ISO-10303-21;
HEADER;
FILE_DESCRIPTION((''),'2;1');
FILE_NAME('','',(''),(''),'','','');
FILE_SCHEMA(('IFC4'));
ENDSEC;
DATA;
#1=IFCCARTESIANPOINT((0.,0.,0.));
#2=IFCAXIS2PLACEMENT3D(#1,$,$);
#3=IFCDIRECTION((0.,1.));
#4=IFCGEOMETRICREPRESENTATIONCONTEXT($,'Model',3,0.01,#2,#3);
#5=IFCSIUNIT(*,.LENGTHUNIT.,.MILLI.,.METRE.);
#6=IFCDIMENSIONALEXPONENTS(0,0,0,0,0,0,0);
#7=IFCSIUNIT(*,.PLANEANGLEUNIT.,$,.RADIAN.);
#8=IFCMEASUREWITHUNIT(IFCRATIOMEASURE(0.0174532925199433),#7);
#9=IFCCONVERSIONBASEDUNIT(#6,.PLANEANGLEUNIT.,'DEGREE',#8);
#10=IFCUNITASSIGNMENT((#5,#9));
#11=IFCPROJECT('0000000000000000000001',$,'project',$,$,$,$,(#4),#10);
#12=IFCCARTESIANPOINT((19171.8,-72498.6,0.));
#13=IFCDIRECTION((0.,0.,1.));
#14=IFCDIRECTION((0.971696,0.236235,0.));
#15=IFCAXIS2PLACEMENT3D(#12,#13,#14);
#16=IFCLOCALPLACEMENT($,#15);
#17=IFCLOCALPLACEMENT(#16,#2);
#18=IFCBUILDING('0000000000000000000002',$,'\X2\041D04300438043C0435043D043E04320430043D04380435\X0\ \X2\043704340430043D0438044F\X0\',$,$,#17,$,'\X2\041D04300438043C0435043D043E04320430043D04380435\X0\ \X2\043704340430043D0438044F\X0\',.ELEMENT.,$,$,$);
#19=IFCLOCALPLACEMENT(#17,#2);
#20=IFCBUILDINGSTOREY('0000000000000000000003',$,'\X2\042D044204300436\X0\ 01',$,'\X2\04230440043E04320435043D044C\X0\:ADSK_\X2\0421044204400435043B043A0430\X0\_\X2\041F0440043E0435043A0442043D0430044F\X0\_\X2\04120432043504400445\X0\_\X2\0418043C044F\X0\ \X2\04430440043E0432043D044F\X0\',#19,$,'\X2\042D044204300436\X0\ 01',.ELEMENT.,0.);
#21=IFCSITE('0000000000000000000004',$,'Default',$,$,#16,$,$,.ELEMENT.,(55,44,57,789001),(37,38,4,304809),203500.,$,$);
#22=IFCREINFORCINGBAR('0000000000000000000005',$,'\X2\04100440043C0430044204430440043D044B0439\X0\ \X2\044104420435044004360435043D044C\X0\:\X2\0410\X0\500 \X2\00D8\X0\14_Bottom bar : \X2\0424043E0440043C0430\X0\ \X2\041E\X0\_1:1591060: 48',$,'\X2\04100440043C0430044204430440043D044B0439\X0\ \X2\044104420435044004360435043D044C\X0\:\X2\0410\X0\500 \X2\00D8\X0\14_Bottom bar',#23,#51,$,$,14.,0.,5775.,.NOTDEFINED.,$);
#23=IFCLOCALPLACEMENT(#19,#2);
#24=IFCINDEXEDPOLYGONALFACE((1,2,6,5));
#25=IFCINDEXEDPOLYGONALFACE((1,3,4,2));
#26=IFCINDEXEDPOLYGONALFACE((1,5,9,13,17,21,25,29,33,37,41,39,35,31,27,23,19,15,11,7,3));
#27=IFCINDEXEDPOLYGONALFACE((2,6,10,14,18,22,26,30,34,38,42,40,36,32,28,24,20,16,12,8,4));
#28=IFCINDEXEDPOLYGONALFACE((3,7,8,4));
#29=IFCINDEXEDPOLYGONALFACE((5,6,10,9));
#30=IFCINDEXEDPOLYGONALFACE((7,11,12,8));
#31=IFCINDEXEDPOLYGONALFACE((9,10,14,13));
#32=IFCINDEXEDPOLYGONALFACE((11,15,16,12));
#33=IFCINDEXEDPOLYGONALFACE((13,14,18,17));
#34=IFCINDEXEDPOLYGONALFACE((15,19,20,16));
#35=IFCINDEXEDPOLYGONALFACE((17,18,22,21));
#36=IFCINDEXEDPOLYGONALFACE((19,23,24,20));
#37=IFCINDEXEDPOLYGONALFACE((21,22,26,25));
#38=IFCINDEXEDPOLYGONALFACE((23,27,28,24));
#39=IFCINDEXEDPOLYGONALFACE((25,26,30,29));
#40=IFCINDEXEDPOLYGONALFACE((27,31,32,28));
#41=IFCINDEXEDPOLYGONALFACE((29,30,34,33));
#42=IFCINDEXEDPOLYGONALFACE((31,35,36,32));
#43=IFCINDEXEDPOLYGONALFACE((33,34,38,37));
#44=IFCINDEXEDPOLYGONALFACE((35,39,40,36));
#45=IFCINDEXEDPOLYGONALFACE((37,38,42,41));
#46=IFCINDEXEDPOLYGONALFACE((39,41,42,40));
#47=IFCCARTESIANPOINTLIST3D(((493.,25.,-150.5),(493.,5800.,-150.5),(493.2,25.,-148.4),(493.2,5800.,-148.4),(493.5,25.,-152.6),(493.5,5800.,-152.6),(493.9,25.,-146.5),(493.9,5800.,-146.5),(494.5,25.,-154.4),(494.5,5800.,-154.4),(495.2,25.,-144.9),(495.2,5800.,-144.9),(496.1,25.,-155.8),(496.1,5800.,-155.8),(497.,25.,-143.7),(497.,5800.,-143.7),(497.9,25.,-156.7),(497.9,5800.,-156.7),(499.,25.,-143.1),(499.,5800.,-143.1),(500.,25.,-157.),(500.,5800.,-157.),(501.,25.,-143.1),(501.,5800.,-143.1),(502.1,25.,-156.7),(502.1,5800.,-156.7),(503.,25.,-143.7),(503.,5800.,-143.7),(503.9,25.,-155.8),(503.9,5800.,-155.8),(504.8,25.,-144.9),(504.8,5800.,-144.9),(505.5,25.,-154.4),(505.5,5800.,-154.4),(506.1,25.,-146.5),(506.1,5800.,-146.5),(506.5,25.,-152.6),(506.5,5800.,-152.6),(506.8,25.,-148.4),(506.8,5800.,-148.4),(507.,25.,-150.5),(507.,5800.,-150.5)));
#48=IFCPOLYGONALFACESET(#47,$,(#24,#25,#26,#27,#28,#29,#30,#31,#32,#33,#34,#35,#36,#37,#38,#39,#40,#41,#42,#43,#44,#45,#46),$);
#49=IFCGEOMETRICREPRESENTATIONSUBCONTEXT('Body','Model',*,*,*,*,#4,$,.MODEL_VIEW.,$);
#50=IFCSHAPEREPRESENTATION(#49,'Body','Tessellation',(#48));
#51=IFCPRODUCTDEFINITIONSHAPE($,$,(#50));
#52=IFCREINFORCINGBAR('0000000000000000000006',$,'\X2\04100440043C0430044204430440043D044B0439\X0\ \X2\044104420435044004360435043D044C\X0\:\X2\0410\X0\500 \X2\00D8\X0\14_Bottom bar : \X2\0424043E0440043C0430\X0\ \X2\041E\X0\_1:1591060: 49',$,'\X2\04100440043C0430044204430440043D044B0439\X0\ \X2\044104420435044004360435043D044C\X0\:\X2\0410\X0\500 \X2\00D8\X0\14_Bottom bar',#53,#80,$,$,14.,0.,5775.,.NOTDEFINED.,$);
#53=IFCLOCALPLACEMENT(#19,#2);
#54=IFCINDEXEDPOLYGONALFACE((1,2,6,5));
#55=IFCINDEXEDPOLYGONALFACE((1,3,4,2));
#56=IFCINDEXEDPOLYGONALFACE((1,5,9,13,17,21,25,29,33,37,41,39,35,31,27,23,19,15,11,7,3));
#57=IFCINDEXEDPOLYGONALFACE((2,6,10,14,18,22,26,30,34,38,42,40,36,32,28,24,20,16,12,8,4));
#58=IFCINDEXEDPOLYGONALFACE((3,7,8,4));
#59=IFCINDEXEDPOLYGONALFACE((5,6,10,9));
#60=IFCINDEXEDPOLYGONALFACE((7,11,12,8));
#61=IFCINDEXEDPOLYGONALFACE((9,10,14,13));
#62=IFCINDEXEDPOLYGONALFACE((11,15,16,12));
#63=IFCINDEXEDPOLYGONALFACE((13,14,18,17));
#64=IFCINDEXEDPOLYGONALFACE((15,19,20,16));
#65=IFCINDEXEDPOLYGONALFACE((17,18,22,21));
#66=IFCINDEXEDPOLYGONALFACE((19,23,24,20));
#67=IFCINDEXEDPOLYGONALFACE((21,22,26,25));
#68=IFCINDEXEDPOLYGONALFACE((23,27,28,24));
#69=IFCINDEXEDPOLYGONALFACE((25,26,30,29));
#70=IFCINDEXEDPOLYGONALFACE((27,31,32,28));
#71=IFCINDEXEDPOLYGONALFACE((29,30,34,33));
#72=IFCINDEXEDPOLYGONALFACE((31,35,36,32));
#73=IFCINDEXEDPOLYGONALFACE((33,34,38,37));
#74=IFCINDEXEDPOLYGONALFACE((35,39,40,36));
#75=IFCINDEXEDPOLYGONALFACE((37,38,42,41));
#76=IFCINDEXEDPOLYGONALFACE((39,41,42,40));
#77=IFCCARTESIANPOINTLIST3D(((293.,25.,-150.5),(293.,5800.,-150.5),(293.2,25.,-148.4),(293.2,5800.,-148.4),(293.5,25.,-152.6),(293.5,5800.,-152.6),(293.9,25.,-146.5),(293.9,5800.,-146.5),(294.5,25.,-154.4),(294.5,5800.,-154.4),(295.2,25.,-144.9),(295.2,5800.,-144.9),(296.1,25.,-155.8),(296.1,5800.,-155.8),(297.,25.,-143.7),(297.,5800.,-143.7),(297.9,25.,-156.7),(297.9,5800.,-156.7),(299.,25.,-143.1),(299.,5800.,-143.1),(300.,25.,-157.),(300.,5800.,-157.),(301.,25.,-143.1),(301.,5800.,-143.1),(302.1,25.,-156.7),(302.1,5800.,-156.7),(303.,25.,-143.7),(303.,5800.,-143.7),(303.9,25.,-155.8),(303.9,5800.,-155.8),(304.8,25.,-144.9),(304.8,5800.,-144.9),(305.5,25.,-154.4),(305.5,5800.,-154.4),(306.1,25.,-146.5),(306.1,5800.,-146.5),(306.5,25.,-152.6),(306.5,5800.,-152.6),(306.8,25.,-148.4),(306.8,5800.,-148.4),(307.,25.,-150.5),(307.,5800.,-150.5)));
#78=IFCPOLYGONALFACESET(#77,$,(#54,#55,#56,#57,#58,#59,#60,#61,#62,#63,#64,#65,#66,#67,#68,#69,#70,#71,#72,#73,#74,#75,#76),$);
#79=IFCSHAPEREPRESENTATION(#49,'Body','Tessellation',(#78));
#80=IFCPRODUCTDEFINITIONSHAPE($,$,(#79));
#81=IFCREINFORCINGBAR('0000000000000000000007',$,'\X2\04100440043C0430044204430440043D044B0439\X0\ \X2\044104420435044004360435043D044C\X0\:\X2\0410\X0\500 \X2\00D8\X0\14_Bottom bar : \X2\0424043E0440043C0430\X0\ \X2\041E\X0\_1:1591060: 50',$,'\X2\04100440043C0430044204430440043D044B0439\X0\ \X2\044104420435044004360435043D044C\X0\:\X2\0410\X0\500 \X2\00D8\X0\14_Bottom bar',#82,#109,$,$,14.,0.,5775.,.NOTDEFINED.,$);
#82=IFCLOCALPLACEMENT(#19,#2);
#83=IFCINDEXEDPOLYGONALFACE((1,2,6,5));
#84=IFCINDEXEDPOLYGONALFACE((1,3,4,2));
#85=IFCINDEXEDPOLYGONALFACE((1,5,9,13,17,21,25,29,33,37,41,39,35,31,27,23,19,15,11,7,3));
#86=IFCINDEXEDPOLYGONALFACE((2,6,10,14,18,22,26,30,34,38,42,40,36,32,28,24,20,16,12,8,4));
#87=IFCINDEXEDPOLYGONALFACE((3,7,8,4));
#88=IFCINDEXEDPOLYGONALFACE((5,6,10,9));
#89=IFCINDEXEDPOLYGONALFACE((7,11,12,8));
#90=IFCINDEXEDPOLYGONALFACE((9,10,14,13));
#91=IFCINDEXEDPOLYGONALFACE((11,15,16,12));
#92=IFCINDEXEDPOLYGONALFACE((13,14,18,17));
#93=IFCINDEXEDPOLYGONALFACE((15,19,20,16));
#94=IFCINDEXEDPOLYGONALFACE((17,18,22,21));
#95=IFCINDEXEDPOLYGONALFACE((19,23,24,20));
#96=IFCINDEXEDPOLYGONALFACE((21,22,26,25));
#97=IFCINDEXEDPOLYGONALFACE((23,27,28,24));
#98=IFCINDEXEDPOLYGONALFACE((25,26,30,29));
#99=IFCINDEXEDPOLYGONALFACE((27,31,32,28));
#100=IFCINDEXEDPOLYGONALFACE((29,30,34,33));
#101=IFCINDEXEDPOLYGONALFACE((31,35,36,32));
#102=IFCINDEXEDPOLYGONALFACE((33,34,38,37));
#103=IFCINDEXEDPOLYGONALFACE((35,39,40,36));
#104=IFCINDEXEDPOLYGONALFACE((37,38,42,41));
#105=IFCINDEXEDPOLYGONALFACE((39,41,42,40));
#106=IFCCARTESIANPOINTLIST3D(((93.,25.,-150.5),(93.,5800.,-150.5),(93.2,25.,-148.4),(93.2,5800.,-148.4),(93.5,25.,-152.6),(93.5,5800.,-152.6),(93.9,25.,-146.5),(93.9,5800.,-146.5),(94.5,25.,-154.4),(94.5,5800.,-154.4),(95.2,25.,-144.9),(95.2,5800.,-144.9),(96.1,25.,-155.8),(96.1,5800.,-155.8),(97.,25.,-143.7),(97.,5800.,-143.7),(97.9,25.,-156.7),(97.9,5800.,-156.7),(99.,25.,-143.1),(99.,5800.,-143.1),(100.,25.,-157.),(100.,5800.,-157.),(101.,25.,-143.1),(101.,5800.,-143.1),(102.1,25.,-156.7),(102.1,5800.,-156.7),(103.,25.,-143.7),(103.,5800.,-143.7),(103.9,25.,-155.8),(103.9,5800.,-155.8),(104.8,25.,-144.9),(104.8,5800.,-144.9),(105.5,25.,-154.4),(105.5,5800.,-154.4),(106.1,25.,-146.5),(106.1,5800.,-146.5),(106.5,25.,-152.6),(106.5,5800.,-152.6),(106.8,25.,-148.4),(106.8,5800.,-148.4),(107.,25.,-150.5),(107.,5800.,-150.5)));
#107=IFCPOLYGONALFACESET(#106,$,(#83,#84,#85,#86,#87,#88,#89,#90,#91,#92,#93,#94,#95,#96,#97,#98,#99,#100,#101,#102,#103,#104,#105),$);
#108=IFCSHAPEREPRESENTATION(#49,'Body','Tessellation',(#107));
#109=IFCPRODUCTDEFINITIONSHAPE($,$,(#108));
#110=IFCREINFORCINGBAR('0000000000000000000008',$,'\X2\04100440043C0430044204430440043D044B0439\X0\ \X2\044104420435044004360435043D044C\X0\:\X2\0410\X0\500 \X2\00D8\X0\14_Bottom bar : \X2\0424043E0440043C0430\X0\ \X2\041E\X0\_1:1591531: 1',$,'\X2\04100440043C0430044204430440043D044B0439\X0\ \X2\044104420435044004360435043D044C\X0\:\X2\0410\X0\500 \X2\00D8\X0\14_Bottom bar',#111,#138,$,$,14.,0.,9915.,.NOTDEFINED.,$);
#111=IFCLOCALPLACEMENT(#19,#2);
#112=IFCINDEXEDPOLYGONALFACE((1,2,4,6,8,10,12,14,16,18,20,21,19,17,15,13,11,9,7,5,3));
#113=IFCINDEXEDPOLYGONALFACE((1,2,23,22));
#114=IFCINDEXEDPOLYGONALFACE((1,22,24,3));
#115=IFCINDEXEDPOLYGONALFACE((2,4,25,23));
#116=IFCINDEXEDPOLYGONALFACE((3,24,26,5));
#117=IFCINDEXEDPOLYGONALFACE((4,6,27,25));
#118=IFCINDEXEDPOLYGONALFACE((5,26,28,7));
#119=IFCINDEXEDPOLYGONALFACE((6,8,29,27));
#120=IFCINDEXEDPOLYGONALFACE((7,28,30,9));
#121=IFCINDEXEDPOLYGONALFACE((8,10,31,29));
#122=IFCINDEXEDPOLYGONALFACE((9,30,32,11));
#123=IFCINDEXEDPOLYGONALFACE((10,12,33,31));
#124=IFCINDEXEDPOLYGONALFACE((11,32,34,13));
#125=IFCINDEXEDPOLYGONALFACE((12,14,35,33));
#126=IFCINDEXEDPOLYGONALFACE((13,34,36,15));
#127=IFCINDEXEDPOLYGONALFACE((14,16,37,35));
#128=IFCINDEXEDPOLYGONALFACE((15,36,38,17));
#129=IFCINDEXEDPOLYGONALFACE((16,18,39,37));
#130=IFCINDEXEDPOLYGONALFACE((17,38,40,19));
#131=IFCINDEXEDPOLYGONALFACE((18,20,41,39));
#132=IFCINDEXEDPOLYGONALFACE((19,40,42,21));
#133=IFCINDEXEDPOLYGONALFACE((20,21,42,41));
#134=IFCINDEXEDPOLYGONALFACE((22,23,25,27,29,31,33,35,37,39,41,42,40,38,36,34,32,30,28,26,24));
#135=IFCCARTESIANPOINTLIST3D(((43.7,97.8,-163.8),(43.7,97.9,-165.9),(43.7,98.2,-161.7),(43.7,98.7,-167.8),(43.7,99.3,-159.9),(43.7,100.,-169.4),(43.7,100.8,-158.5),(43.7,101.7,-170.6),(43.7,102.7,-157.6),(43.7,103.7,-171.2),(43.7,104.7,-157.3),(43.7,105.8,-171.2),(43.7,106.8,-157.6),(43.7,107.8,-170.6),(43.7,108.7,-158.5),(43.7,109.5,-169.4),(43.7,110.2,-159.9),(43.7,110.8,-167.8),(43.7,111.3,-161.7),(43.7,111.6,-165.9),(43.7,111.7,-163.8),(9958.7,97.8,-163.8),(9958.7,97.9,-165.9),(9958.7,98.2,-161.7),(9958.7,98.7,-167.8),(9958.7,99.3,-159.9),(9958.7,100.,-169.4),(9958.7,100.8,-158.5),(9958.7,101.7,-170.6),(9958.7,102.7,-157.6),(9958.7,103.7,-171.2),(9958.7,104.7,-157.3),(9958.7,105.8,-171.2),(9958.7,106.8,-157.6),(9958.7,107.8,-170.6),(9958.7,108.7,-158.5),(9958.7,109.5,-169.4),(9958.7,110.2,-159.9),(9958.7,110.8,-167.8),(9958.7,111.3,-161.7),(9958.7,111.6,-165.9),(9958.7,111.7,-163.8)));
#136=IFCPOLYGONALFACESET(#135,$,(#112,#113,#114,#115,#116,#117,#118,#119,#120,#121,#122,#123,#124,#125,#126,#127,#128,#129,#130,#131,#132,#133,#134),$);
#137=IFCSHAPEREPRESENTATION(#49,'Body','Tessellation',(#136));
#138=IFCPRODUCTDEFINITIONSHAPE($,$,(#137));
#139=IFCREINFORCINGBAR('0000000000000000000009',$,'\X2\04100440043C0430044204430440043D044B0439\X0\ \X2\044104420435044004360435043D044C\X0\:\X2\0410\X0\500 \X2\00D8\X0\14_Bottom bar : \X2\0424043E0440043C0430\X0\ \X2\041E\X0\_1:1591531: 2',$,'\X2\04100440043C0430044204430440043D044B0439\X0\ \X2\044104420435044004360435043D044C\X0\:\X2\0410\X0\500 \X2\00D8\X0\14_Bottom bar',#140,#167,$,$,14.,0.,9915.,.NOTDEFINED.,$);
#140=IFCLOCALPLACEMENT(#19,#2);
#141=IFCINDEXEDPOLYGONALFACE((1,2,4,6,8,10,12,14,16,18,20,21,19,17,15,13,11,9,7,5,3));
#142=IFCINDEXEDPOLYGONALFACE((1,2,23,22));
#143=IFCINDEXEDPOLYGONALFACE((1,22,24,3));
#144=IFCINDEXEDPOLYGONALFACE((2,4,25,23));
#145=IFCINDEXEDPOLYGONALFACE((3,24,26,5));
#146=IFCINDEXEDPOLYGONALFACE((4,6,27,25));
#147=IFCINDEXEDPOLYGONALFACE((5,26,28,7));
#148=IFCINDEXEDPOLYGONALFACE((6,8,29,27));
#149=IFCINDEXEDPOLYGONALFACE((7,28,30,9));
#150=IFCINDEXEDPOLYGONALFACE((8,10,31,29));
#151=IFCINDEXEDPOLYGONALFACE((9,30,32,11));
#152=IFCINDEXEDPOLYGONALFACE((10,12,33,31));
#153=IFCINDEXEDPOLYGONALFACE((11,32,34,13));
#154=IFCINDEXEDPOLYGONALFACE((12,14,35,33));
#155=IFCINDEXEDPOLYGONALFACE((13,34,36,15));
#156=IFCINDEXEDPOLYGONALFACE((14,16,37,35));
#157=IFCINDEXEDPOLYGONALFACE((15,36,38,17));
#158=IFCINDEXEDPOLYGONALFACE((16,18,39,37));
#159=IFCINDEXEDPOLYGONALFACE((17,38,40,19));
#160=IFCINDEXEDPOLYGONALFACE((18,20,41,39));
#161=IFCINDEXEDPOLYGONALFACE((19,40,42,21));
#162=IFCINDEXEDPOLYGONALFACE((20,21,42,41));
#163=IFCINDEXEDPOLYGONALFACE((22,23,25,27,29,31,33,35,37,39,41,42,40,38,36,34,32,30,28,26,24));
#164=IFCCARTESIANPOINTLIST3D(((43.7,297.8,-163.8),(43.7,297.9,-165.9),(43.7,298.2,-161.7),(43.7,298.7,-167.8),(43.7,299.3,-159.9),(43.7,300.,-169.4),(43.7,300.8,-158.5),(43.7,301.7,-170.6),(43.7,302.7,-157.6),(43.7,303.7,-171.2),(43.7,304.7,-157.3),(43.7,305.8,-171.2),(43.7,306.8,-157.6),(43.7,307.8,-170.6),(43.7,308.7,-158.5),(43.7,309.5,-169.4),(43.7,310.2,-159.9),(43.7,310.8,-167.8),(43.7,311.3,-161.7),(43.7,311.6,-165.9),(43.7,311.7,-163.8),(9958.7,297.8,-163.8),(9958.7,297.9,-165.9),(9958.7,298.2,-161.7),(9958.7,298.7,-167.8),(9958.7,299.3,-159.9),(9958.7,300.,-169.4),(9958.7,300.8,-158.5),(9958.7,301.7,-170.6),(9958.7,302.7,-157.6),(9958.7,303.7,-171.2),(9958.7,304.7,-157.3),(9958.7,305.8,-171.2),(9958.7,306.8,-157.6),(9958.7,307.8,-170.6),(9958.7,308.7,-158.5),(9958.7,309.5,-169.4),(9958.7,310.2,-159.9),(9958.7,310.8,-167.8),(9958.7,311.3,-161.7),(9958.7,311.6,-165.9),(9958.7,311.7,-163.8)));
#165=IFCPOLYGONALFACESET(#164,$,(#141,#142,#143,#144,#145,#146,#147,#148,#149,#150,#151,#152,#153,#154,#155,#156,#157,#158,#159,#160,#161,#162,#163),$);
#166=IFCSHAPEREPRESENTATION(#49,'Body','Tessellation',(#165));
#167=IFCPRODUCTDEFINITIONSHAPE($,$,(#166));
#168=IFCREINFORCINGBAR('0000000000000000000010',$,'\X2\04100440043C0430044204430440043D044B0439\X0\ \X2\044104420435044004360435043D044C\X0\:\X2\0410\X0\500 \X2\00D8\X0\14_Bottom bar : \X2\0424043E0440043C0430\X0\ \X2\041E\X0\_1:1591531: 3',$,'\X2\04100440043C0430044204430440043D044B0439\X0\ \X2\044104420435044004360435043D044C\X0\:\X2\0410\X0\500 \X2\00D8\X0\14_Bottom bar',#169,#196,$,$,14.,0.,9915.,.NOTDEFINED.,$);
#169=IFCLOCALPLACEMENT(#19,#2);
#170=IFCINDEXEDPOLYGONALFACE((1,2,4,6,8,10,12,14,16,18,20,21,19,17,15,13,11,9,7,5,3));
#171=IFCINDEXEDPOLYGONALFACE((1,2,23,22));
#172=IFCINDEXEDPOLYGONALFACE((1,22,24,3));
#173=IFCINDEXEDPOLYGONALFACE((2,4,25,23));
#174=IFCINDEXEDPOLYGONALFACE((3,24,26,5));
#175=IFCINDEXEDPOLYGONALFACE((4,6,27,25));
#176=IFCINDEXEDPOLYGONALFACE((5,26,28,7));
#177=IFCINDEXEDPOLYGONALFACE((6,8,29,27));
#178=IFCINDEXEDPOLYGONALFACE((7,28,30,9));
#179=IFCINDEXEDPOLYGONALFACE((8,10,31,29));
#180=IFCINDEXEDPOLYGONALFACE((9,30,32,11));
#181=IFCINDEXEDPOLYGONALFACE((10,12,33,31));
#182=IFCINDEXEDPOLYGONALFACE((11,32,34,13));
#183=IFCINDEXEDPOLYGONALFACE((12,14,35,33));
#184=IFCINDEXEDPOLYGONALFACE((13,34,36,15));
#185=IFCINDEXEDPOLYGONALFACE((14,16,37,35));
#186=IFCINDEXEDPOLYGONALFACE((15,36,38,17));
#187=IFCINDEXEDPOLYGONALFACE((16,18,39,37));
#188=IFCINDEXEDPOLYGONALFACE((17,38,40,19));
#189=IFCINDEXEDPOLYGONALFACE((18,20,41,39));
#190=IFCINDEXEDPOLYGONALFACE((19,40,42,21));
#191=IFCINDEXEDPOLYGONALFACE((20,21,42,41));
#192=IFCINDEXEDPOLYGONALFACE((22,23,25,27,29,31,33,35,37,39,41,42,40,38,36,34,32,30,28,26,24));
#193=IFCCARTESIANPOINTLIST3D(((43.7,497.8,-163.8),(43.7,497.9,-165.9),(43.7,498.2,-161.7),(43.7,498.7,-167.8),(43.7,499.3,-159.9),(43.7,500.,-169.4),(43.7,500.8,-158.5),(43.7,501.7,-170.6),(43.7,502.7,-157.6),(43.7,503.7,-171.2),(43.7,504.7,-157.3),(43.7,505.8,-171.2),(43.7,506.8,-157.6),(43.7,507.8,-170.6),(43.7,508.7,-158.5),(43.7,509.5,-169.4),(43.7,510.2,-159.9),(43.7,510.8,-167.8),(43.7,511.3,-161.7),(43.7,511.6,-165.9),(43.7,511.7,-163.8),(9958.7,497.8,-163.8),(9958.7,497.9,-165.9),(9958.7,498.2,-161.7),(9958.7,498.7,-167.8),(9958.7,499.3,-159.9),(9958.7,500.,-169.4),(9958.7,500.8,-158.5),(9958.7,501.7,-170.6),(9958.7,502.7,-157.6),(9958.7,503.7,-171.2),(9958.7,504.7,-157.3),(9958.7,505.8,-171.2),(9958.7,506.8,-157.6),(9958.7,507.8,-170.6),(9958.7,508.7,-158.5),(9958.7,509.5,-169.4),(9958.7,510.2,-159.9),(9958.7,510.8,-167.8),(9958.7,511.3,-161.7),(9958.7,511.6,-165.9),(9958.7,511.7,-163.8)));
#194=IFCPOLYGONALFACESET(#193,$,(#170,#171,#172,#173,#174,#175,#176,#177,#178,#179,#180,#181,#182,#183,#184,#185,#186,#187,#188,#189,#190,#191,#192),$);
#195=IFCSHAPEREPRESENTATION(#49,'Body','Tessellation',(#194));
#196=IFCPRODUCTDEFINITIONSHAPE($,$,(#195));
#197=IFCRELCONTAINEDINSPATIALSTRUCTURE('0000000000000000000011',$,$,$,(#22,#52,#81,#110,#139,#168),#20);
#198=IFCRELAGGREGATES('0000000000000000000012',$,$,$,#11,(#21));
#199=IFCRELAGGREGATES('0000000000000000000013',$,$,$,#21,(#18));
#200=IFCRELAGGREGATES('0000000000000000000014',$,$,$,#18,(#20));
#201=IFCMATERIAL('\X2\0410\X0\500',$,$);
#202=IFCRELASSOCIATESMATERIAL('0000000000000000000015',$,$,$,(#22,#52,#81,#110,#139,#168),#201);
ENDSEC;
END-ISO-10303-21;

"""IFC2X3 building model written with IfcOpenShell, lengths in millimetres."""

from ifc_helpers import new_model, entity, si_unit, converted_unit, direction, frame, origin, place, context, subcontext, project, spatial, material, element, save


model = new_model("IFC2X3")

# Units and contexts
model_context = context("Model", 3, precision=0.01, world=origin(), true_north=direction((0.0, 1.0)))
body_context = subcontext(model_context, "Body", "Model", "MODEL_VIEW")
ifc_project = project(units=[si_unit("LENGTHUNIT", "METRE", prefix="MILLI"), converted_unit("PLANEANGLEUNIT", "DEGREE", entity("IfcRatioMeasure", 0.0174532925199433), si_unit("PLANEANGLEUNIT", "RADIAN"), dimensions=[0, 0, 0, 0, 0, 0, 0])], contexts=[model_context])

# Site, building, storey
site_placement = place(None, frame((19171.8, -72498.6, 0.0), z_axis=(0.0, 0.0, 1.0), x_axis=(0.971696, 0.236235, 0.0)))
site = spatial("IfcSite", under=ifc_project, at=site_placement, Name="Default", CompositionType="ELEMENT", RefLatitude=(55, 44, 57, 789001), RefLongitude=(37, 38, 4, 304809), RefElevation=203500.0)
building_placement = place(site_placement, origin())
building = spatial("IfcBuilding", under=site, at=building_placement, Name="Наименование здания", LongName="Наименование здания", CompositionType="ELEMENT")
storey_placement = place(building_placement, origin())
storey = spatial("IfcBuildingStorey", under=building, at=storey_placement, Name="Этаж 01", ObjectType="Уровень:ADSK_Стрелка_Проектная_Вверх_Имя уровня", LongName="Этаж 01", CompositionType="ELEMENT", Elevation=0.0)

# Reinforcing bars
ifc_material = material(Name="А500")
placement = place(storey_placement, origin())
element("IfcReinforcingBar", 1, at=placement, inside=storey, material=ifc_material, Name="Арматурный стержень:А500 Ø14_Bottom bar : Форма О_1:1591060: 48", ObjectType="Арматурный стержень:А500 Ø14_Bottom bar", BarLength=5775.0, BarRole="NOTDEFINED", CrossSectionArea=0.0, NominalDiameter=14.0, context=body_context, shape_type="AdvancedSweptSolid", body=[
    entity("IfcSweptDiskSolid", entity("IfcCompositeCurve", [entity("IfcCompositeCurveSegment", "CONTINUOUS", True, entity("IfcPolyline", [entity("IfcCartesianPoint", [500.0, 5800.0, -150.0]), entity("IfcCartesianPoint", [500.0, 25.0, -150.0])]))], False), 7.0, None, 0.0, 1.0),
])
element("IfcReinforcingBar", 2, at=placement, inside=storey, material=ifc_material, Name="Арматурный стержень:А500 Ø14_Bottom bar : Форма О_1:1591060: 49", ObjectType="Арматурный стержень:А500 Ø14_Bottom bar", BarLength=5775.0, BarRole="NOTDEFINED", CrossSectionArea=0.0, NominalDiameter=14.0, context=body_context, shape_type="AdvancedSweptSolid", body=[
    entity("IfcSweptDiskSolid", entity("IfcCompositeCurve", [entity("IfcCompositeCurveSegment", "CONTINUOUS", True, entity("IfcPolyline", [entity("IfcCartesianPoint", [300.0, 5800.0, -150.0]), entity("IfcCartesianPoint", [300.0, 25.0, -150.0])]))], False), 7.0, None, 0.0, 1.0),
])
element("IfcReinforcingBar", 3, at=placement, inside=storey, material=ifc_material, Name="Арматурный стержень:А500 Ø14_Bottom bar : Форма О_1:1591060: 50", ObjectType="Арматурный стержень:А500 Ø14_Bottom bar", BarLength=5775.0, BarRole="NOTDEFINED", CrossSectionArea=0.0, NominalDiameter=14.0, context=body_context, shape_type="AdvancedSweptSolid", body=[
    entity("IfcSweptDiskSolid", entity("IfcCompositeCurve", [entity("IfcCompositeCurveSegment", "CONTINUOUS", True, entity("IfcPolyline", [entity("IfcCartesianPoint", [100.0, 5800.0, -150.0]), entity("IfcCartesianPoint", [100.0, 25.0, -150.0])]))], False), 7.0, None, 0.0, 1.0),
])
element("IfcReinforcingBar", 4, at=placement, inside=storey, material=ifc_material, Name="Арматурный стержень:А500 Ø14_Bottom bar : Форма О_1:1591531: 1", ObjectType="Арматурный стержень:А500 Ø14_Bottom bar", BarLength=9915.0, BarRole="NOTDEFINED", CrossSectionArea=0.0, NominalDiameter=14.0, context=body_context, shape_type="AdvancedSweptSolid", body=[
    entity("IfcSweptDiskSolid", entity("IfcCompositeCurve", [entity("IfcCompositeCurveSegment", "CONTINUOUS", True, entity("IfcPolyline", [entity("IfcCartesianPoint", [43.7, 104.7, -164.3]), entity("IfcCartesianPoint", [9958.7, 104.7, -164.3])]))], False), 7.0, None, 0.0, 1.0),
])
element("IfcReinforcingBar", 5, at=placement, inside=storey, material=ifc_material, Name="Арматурный стержень:А500 Ø14_Bottom bar : Форма О_1:1591531: 2", ObjectType="Арматурный стержень:А500 Ø14_Bottom bar", BarLength=9915.0, BarRole="NOTDEFINED", CrossSectionArea=0.0, NominalDiameter=14.0, context=body_context, shape_type="AdvancedSweptSolid", body=[
    entity("IfcSweptDiskSolid", entity("IfcCompositeCurve", [entity("IfcCompositeCurveSegment", "CONTINUOUS", True, entity("IfcPolyline", [entity("IfcCartesianPoint", [43.7, 304.7, -164.3]), entity("IfcCartesianPoint", [9958.7, 304.7, -164.3])]))], False), 7.0, None, 0.0, 1.0),
])
element("IfcReinforcingBar", 6, at=placement, inside=storey, material=ifc_material, Name="Арматурный стержень:А500 Ø14_Bottom bar : Форма О_1:1591531: 3", ObjectType="Арматурный стержень:А500 Ø14_Bottom bar", BarLength=9915.0, BarRole="NOTDEFINED", CrossSectionArea=0.0, NominalDiameter=14.0, context=body_context, shape_type="AdvancedSweptSolid", body=[
    entity("IfcSweptDiskSolid", entity("IfcCompositeCurve", [entity("IfcCompositeCurveSegment", "CONTINUOUS", True, entity("IfcPolyline", [entity("IfcCartesianPoint", [43.7, 504.7, -164.3]), entity("IfcCartesianPoint", [9958.7, 504.7, -164.3])]))], False), 7.0, None, 0.0, 1.0),
])

save(model, "model.ifc")
